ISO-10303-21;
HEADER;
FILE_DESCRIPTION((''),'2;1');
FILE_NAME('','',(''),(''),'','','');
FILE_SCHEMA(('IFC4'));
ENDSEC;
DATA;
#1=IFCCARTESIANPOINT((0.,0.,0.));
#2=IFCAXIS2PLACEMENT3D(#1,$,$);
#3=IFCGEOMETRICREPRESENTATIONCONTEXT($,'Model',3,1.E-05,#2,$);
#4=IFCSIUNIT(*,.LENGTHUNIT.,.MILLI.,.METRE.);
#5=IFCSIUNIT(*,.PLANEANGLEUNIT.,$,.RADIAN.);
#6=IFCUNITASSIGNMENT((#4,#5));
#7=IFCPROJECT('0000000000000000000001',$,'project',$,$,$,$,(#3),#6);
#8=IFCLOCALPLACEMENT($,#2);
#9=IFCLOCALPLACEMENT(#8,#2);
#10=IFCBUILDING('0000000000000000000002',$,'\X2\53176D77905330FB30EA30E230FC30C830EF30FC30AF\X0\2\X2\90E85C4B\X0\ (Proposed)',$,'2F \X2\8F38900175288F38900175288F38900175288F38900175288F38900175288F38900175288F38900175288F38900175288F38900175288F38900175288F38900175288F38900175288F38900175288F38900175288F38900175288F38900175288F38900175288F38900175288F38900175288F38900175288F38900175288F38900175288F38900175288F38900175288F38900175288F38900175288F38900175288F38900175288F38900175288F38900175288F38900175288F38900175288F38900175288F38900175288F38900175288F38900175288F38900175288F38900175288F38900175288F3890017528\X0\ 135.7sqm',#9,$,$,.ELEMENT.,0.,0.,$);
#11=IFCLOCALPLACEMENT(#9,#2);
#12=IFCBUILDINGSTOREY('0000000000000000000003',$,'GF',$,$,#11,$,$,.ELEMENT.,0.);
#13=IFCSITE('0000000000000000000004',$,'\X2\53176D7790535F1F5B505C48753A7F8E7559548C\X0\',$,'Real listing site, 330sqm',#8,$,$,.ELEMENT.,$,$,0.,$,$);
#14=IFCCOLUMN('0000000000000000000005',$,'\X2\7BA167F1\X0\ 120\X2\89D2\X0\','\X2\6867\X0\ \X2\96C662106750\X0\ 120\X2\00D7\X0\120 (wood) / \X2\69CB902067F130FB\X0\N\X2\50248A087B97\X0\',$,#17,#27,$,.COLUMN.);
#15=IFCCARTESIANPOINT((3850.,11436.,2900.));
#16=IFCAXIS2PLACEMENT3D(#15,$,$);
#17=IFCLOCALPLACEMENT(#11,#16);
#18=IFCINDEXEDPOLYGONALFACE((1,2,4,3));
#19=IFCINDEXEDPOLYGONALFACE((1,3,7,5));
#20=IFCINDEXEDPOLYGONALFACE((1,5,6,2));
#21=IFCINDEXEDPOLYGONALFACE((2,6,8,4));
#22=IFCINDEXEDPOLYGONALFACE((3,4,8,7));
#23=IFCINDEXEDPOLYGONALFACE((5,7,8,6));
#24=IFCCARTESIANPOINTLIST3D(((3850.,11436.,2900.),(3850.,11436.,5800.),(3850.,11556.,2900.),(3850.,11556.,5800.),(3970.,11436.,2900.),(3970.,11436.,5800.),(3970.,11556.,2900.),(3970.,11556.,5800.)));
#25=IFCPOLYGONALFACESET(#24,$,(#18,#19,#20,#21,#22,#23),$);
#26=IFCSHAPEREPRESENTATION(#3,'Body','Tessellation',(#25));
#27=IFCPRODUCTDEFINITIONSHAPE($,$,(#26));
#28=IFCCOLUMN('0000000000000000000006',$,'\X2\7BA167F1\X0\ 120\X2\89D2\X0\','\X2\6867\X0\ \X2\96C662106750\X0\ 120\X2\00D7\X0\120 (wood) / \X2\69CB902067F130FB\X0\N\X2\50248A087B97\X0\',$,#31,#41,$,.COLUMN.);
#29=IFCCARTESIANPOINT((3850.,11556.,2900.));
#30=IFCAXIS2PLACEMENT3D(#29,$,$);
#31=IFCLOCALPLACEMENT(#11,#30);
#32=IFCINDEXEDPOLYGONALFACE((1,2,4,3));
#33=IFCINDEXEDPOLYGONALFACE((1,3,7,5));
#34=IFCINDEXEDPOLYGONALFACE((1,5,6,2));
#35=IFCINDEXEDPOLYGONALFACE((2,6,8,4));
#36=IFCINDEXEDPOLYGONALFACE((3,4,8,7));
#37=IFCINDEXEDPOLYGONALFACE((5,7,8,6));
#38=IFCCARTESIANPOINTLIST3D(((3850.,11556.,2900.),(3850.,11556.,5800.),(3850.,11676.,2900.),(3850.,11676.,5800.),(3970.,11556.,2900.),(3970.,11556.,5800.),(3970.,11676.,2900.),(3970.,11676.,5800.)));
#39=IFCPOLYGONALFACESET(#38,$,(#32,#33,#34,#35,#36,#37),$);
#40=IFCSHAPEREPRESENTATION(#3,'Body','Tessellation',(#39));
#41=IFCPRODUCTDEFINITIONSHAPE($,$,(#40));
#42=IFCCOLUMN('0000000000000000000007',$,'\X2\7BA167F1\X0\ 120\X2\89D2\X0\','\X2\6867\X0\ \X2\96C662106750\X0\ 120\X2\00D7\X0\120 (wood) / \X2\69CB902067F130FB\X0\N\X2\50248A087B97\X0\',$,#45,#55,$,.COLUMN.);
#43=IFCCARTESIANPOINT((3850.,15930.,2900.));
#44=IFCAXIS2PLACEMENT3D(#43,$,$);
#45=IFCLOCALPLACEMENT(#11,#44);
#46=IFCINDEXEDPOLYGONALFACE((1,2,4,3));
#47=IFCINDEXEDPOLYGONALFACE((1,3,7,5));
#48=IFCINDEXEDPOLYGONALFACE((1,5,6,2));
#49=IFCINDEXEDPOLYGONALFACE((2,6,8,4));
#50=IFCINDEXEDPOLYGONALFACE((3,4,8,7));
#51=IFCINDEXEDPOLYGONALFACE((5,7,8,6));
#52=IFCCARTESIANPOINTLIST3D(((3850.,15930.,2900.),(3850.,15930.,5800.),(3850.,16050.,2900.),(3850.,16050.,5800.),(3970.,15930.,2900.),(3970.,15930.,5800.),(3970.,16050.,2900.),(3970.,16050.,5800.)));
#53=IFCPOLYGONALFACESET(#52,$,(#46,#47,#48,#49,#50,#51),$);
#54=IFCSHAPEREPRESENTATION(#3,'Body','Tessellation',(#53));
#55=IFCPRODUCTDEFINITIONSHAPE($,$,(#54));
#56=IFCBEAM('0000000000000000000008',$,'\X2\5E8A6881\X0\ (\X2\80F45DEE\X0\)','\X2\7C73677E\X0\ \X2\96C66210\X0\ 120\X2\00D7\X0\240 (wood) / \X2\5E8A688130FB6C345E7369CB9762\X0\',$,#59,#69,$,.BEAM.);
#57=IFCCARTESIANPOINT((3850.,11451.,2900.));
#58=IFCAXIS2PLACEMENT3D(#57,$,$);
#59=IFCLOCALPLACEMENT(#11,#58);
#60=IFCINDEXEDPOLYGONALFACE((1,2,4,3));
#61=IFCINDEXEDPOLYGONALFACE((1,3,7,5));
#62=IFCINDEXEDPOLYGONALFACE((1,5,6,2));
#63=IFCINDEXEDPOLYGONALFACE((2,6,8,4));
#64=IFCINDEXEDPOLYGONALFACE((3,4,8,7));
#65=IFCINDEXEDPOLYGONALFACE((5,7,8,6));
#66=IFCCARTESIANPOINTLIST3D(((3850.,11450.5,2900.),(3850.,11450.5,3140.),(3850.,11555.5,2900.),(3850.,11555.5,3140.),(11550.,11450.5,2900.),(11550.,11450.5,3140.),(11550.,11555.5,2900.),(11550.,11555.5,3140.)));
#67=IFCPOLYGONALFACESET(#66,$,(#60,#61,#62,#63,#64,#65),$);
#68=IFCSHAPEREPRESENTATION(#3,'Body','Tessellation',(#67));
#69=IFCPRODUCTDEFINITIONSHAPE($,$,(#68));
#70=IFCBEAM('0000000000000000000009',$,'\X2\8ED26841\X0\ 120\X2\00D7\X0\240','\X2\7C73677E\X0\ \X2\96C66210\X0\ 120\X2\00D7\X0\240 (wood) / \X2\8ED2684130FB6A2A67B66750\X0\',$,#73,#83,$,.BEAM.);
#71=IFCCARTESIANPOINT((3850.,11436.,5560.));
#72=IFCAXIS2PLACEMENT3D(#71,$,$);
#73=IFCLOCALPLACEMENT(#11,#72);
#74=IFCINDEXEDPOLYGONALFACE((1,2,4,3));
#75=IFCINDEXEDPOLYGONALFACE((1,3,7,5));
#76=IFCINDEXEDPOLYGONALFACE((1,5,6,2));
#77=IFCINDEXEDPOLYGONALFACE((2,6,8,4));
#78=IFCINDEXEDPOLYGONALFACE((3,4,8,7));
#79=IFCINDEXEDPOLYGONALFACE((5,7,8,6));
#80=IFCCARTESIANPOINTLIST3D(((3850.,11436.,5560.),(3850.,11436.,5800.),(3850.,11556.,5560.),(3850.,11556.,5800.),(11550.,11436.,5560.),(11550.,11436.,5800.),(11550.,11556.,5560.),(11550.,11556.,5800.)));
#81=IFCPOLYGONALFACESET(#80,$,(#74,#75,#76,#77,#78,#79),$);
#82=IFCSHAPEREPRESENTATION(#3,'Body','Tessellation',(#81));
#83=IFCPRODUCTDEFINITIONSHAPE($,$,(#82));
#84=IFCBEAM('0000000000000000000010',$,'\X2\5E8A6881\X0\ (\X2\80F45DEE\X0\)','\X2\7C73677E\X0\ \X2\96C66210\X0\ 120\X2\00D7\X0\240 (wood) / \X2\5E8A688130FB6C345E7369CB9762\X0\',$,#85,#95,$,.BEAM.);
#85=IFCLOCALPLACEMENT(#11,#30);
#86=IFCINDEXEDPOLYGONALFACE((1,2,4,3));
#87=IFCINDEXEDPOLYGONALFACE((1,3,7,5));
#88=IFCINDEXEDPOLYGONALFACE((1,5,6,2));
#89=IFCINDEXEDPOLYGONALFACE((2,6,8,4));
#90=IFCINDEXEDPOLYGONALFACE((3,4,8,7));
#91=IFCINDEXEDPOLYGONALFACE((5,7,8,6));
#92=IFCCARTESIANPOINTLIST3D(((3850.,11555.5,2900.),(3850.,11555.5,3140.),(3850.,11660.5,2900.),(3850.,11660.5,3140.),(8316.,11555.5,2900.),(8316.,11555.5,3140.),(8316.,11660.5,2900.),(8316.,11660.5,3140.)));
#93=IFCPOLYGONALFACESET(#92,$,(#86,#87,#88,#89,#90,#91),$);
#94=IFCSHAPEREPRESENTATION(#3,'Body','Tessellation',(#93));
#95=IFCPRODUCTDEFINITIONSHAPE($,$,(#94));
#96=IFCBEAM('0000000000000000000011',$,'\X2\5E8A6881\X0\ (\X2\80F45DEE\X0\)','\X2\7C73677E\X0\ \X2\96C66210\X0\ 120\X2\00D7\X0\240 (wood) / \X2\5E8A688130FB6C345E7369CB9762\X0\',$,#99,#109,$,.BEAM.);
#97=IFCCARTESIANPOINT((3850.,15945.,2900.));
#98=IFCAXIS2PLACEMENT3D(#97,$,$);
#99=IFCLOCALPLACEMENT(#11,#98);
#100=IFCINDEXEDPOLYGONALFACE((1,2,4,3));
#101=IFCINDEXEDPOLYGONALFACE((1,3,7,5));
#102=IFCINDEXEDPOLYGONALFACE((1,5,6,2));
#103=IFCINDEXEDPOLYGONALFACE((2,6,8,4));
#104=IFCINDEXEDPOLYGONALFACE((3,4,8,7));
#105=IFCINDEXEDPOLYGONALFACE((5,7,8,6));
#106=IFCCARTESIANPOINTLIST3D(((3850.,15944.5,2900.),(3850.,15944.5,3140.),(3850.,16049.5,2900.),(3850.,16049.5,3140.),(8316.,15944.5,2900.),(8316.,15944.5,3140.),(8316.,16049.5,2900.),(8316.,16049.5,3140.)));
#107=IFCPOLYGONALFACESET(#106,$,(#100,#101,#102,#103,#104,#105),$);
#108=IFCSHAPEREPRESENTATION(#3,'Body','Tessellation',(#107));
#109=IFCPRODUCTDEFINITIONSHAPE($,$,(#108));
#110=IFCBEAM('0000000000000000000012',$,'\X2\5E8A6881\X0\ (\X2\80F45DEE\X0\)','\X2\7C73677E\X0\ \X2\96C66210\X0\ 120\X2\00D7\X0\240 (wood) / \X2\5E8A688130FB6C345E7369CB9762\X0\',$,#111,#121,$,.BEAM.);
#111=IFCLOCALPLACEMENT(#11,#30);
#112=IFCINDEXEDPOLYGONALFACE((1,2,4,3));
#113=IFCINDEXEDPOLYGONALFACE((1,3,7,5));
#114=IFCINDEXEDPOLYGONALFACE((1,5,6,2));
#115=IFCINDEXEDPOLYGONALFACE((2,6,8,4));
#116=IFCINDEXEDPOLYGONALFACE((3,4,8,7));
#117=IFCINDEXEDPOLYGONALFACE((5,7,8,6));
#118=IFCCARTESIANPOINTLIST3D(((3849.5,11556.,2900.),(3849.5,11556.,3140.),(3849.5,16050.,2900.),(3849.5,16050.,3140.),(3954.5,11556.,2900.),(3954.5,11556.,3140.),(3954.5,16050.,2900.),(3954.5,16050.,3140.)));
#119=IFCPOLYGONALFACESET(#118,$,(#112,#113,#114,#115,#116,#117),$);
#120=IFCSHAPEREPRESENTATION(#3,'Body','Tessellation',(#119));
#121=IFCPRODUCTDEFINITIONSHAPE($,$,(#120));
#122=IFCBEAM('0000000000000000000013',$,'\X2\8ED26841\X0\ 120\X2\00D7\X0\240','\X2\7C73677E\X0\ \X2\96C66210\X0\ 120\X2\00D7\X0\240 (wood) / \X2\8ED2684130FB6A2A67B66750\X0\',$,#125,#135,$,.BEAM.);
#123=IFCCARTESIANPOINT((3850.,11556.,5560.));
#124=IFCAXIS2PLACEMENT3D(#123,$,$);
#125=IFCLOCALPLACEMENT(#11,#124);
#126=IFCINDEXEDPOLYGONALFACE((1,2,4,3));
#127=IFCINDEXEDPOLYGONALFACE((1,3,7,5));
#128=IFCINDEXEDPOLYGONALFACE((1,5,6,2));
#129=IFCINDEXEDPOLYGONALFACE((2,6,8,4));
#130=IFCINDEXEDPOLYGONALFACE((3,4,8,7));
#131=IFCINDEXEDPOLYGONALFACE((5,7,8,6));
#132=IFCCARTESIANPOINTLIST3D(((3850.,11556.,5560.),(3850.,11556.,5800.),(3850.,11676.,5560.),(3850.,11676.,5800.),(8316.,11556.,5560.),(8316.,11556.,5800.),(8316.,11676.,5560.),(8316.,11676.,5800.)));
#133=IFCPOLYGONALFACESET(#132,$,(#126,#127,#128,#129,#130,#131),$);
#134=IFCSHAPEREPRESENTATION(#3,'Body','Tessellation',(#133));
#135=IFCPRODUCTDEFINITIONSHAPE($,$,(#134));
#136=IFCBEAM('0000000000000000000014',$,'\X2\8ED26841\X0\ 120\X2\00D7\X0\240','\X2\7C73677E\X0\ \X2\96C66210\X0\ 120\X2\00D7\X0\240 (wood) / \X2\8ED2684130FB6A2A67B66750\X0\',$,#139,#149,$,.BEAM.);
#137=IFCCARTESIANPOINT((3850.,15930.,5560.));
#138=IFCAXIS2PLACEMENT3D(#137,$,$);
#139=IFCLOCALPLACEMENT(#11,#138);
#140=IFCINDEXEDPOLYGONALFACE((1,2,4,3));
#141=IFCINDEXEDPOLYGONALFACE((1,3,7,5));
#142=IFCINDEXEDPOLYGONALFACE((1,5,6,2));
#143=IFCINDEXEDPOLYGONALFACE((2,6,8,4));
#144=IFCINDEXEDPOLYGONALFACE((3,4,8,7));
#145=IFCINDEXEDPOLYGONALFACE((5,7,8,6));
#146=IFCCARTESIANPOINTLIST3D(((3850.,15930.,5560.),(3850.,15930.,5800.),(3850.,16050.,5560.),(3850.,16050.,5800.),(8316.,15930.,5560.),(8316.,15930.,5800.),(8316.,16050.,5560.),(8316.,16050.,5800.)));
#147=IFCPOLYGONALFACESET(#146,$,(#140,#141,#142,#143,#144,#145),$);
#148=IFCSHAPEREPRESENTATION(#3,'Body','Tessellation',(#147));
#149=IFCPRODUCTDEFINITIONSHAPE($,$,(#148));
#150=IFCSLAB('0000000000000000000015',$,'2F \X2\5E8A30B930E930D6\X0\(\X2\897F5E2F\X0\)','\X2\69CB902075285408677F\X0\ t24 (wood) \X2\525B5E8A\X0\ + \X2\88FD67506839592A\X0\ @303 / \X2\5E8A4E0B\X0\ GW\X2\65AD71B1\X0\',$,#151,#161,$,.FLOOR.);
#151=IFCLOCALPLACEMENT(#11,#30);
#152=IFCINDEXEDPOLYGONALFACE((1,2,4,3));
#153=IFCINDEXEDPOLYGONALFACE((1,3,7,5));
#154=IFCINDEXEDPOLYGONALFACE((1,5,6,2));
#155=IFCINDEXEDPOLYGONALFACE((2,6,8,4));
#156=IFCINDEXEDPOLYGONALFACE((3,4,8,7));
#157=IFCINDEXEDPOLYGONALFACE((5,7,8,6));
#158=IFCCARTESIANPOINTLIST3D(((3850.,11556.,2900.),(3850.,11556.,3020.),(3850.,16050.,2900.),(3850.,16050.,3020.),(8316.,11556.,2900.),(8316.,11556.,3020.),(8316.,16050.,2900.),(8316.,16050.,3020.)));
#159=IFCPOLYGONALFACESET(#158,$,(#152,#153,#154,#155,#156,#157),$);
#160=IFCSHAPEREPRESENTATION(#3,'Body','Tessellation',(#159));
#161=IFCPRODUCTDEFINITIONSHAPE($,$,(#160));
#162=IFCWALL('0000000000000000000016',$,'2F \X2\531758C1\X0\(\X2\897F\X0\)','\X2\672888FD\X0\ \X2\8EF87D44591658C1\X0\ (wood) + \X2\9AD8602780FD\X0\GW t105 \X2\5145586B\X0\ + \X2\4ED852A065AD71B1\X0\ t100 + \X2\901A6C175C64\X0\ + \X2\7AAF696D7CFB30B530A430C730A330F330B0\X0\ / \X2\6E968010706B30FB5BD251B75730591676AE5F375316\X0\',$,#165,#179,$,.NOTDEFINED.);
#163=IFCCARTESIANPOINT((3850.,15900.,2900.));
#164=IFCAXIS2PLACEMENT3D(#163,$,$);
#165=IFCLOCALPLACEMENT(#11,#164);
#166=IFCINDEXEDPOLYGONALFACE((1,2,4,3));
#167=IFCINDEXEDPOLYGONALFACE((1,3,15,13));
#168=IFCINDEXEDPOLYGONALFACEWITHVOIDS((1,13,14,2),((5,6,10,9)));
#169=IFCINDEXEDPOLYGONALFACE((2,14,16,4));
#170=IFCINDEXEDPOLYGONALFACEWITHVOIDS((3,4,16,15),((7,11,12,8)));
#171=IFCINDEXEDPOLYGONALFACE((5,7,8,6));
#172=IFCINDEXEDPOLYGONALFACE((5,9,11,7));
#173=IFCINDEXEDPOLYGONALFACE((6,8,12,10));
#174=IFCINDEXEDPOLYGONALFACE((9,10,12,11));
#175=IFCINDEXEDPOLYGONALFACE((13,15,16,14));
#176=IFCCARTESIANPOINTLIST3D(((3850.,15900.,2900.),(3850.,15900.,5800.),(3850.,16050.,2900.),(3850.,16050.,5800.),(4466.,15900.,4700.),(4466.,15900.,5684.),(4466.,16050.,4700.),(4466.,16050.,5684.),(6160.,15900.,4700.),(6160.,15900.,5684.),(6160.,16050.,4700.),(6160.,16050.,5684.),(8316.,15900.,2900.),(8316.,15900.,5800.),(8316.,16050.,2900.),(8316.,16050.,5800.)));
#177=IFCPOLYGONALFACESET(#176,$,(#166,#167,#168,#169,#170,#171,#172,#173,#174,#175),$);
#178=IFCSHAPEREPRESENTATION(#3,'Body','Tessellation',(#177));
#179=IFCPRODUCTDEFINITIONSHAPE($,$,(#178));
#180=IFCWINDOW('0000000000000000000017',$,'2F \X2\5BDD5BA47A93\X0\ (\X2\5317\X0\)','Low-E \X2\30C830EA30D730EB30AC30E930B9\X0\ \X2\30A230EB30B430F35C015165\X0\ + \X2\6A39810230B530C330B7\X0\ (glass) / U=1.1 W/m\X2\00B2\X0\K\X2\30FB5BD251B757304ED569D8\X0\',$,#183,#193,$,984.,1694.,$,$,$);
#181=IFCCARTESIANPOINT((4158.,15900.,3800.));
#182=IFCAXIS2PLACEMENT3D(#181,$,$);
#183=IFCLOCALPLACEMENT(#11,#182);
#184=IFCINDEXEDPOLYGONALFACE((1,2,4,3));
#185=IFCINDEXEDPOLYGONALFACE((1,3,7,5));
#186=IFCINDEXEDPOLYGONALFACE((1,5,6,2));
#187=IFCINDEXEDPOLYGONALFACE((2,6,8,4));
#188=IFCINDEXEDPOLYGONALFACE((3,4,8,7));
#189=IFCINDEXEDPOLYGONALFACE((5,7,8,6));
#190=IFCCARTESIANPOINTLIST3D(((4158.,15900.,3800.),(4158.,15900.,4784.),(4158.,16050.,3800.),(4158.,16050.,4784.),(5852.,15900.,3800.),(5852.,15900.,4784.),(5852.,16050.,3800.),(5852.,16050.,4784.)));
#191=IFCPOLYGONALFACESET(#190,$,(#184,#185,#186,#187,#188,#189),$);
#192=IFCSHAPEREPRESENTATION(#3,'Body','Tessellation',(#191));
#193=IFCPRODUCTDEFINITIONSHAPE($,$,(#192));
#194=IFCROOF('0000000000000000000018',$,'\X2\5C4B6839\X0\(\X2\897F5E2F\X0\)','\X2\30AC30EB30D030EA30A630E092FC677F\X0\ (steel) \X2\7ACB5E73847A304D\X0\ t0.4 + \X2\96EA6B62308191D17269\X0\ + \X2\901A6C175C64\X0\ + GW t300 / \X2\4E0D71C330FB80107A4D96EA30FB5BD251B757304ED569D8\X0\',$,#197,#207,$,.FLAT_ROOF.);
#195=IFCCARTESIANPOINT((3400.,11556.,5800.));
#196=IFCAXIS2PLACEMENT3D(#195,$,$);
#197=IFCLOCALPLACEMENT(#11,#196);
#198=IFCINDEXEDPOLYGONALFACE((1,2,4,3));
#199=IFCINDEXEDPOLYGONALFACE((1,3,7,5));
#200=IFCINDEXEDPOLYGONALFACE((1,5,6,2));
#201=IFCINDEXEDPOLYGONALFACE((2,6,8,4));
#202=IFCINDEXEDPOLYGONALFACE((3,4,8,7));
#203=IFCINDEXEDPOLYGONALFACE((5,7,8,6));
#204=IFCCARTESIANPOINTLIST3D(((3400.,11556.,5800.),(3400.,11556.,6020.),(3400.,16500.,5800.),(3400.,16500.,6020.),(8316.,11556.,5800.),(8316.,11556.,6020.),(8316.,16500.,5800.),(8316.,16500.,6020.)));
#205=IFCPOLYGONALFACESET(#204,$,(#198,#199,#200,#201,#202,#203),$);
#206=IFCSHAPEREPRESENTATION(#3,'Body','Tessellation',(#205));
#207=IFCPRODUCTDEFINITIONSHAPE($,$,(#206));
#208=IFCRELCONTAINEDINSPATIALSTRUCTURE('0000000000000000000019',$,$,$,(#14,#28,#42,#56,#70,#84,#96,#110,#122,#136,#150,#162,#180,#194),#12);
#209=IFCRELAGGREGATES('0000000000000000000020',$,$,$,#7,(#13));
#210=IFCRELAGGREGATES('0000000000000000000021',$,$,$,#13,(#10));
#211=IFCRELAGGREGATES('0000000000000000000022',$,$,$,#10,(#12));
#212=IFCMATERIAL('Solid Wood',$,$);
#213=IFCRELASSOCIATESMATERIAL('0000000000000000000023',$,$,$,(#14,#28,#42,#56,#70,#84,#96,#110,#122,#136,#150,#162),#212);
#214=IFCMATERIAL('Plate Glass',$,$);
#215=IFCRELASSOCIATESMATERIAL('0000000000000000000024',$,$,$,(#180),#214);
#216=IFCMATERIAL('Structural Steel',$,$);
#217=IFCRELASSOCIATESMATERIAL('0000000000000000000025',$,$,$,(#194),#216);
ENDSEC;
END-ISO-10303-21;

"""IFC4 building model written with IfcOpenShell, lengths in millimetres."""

from ifc_helpers import new_model, si_unit, frame, frame_2d, origin, place, context, project, spatial, rectangle, extrude, material, element, fill, save


model = new_model("IFC4")

# Units and contexts
model_context = context("Model", 3, precision=1e-05, world=origin())
ifc_project = project(units=[si_unit("LENGTHUNIT", "METRE", prefix="MILLI"), si_unit("PLANEANGLEUNIT", "RADIAN")], contexts=[model_context])

# Site, building, storey
site_placement = place(None, origin())
site = spatial("IfcSite", under=ifc_project, at=site_placement, Name="北海道弟子屈町美留和", ObjectType="Real listing site, 330sqm", CompositionType="ELEMENT", RefElevation=0.0)
building_placement = place(site_placement, origin())
building = spatial("IfcBuilding", under=site, at=building_placement, Name="北海道・リモートワーク2部屋 (Proposed)", ObjectType="2F 輸送用輸送用輸送用輸送用輸送用輸送用輸送用輸送用輸送用輸送用輸送用輸送用輸送用輸送用輸送用輸送用輸送用輸送用輸送用輸送用輸送用輸送用輸送用輸送用輸送用輸送用輸送用輸送用輸送用輸送用輸送用輸送用輸送用輸送用輸送用輸送用輸送用輸送用輸送用輸送用 135.7sqm", CompositionType="ELEMENT", ElevationOfRefHeight=0.0, ElevationOfTerrain=0.0)
storey_placement = place(building_placement, origin())
storey = spatial("IfcBuildingStorey", under=building, at=storey_placement, Name="GF", CompositionType="ELEMENT", Elevation=0.0)

# Columns
ifc_material_1 = material(Name="Solid Wood")
column_1_placement = place(storey_placement, frame((3850.0, 11436.0, 2900.0)))
element("IfcColumn", 1, at=column_1_placement, inside=storey, material=ifc_material_1, Name="管柱 120角", Description="桧 集成材 120×120 (wood) / 構造柱・N値計算", PredefinedType="COLUMN", context=model_context, shape_type="SweptSolid", body=[
    extrude(rectangle(XDim=120.0, YDim=120.0, at=frame_2d((60.0, 60.0))), frame((3850.0, 11436.0, 2900.0)), (0.0, 0.0, 1.0), 2900.0),
])
column_2_placement = place(storey_placement, frame((3850.0, 11556.0, 2900.0)))
element("IfcColumn", 2, at=column_2_placement, inside=storey, material=ifc_material_1, Name="管柱 120角", Description="桧 集成材 120×120 (wood) / 構造柱・N値計算", PredefinedType="COLUMN", context=model_context, shape_type="SweptSolid", body=[
    extrude(rectangle(XDim=120.0, YDim=120.0, at=frame_2d((60.0, 60.0))), frame((3850.0, 11556.0, 2900.0)), (0.0, 0.0, 1.0), 2900.0),
])
column_3_placement = place(storey_placement, frame((3850.0, 15930.0, 2900.0)))
element("IfcColumn", 3, at=column_3_placement, inside=storey, material=ifc_material_1, Name="管柱 120角", Description="桧 集成材 120×120 (wood) / 構造柱・N値計算", PredefinedType="COLUMN", context=model_context, shape_type="SweptSolid", body=[
    extrude(rectangle(XDim=120.0, YDim=120.0, at=frame_2d((60.0, 60.0))), frame((3850.0, 15930.0, 2900.0)), (0.0, 0.0, 1.0), 2900.0),
])

# Beams
beam_1_placement = place(storey_placement, frame((3850.0, 11451.0, 2900.0)))
element("IfcBeam", 4, at=beam_1_placement, inside=storey, material=ifc_material_1, Name="床梁 (胴差)", Description="米松 集成 120×240 (wood) / 床梁・水平構面", PredefinedType="BEAM", context=model_context, shape_type="SweptSolid", body=[
    extrude(rectangle(XDim=7700.0, YDim=105.0, at=frame_2d((3850.0, 52.0))), frame((3850.0, 11451.0, 2900.0)), (0.0, 0.0, 1.0), 240.0),
])
beam_2_placement = place(storey_placement, frame((3850.0, 11436.0, 5560.0)))
element("IfcBeam", 5, at=beam_2_placement, inside=storey, material=ifc_material_1, Name="軒桁 120×240", Description="米松 集成 120×240 (wood) / 軒桁・横架材", PredefinedType="BEAM", context=model_context, shape_type="SweptSolid", body=[
    extrude(rectangle(XDim=7700.0, YDim=120.0, at=frame_2d((3850.0, 60.0))), frame((3850.0, 11436.0, 5560.0)), (0.0, 0.0, 1.0), 240.0),
])
beam_3_placement = place(storey_placement, frame((3850.0, 11556.0, 2900.0)))
element("IfcBeam", 6, at=beam_3_placement, inside=storey, material=ifc_material_1, Name="床梁 (胴差)", Description="米松 集成 120×240 (wood) / 床梁・水平構面", PredefinedType="BEAM", context=model_context, shape_type="SweptSolid", body=[
    extrude(rectangle(XDim=4466.0, YDim=105.0, at=frame_2d((2233.0, 52.0))), frame((3850.0, 11556.0, 2900.0)), (0.0, 0.0, 1.0), 240.0),
])
beam_4_placement = place(storey_placement, frame((3850.0, 15945.0, 2900.0)))
element("IfcBeam", 7, at=beam_4_placement, inside=storey, material=ifc_material_1, Name="床梁 (胴差)", Description="米松 集成 120×240 (wood) / 床梁・水平構面", PredefinedType="BEAM", context=model_context, shape_type="SweptSolid", body=[
    extrude(rectangle(XDim=4466.0, YDim=105.0, at=frame_2d((2233.0, 52.0))), frame((3850.0, 15945.0, 2900.0)), (0.0, 0.0, 1.0), 240.0),
])
beam_5_placement = place(storey_placement, frame((3850.0, 11556.0, 2900.0)))
element("IfcBeam", 8, at=beam_5_placement, inside=storey, material=ifc_material_1, Name="床梁 (胴差)", Description="米松 集成 120×240 (wood) / 床梁・水平構面", PredefinedType="BEAM", context=model_context, shape_type="SweptSolid", body=[
    extrude(rectangle(XDim=105.0, YDim=4494.0, at=frame_2d((52.0, 2247.0))), frame((3850.0, 11556.0, 2900.0)), (0.0, 0.0, 1.0), 240.0),
])
beam_6_placement = place(storey_placement, frame((3850.0, 11556.0, 5560.0)))
element("IfcBeam", 9, at=beam_6_placement, inside=storey, material=ifc_material_1, Name="軒桁 120×240", Description="米松 集成 120×240 (wood) / 軒桁・横架材", PredefinedType="BEAM", context=model_context, shape_type="SweptSolid", body=[
    extrude(rectangle(XDim=4466.0, YDim=120.0, at=frame_2d((2233.0, 60.0))), frame((3850.0, 11556.0, 5560.0)), (0.0, 0.0, 1.0), 240.0),
])
beam_7_placement = place(storey_placement, frame((3850.0, 15930.0, 5560.0)))
element("IfcBeam", 10, at=beam_7_placement, inside=storey, material=ifc_material_1, Name="軒桁 120×240", Description="米松 集成 120×240 (wood) / 軒桁・横架材", PredefinedType="BEAM", context=model_context, shape_type="SweptSolid", body=[
    extrude(rectangle(XDim=4466.0, YDim=120.0, at=frame_2d((2233.0, 60.0))), frame((3850.0, 15930.0, 5560.0)), (0.0, 0.0, 1.0), 240.0),
])

# Slab
slab_placement = place(storey_placement, frame((3850.0, 11556.0, 2900.0)))
element("IfcSlab", 11, at=slab_placement, inside=storey, material=ifc_material_1, Name="2F 床スラブ(西帯)", Description="構造用合板 t24 (wood) 剛床 + 製材根太 @303 / 床下 GW断熱", PredefinedType="FLOOR", context=model_context, shape_type="SweptSolid", body=[
    extrude(rectangle(XDim=4466.0, YDim=4494.0, at=frame_2d((2233.0, 2247.0))), frame((3850.0, 11556.0, 2900.0)), (0.0, 0.0, 1.0), 120.0),
])

# Wall, opening, window
wall_1_placement = place(storey_placement, frame((3850.0, 15900.0, 2900.0)))
wall_1 = element("IfcWall", 12, at=wall_1_placement, inside=storey, material=ifc_material_1, Name="2F 北壁(西)", Description="木製 軸組外壁 (wood) + 高性能GW t105 充填 + 付加断熱 t100 + 通気層 + 窯業系サイディング / 準耐火・寒冷地外皮強化", PredefinedType="NOTDEFINED", context=model_context, shape_type="SweptSolid", body=[
    extrude(rectangle(XDim=4466.0, YDim=150.0, at=frame_2d((2233.0, 75.0))), frame((3850.0, 15900.0, 2900.0)), (0.0, 0.0, 1.0), 2900.0),
])
opening_placement = place(storey_placement, frame((4158.0, 15900.0, 3800.0)))
opening = element("IfcOpeningElement", 13, at=opening_placement, cuts=wall_1, PredefinedType="NOTDEFINED", context=model_context, shape_type="SweptSolid", body=[
    extrude(rectangle(XDim=1694.0, YDim=150.0, at=frame_2d((847.0, 75.0))), frame((4158.0, 15900.0, 3800.0)), (0.0, 0.0, 1.0), 984.0),
])
ifc_material_2 = material(Name="Plate Glass")
window_placement = place(storey_placement, frame((4158.0, 15900.0, 3800.0)))
window = element("IfcWindow", 14, at=window_placement, inside=storey, material=ifc_material_2, Name="2F 寝室窓 (北)", Description="Low-E トリプルガラス アルゴン封入 + 樹脂サッシ (glass) / U=1.1 W/m²K・寒冷地仕様", OverallHeight=984.0, OverallWidth=1694.0, context=model_context, shape_type="SweptSolid", body=[
    extrude(rectangle(XDim=1694.0, YDim=150.0, at=frame_2d((847.0, 75.0))), frame((4158.0, 15900.0, 3800.0)), (0.0, 0.0, 1.0), 984.0),
])
fill(opening, window)

# Roof
ifc_material_3 = material(Name="Structural Steel")
for number, where, name in (
    (15, (3400.0, 11556.0, 5800.0), "屋根(西帯)"),
):
    element("IfcRoof", number, at=place(storey_placement, frame(where)), inside=storey, material=ifc_material_3, Name=name, Description="ガルバリウム鋼板 (steel) 立平葺き t0.4 + 雪止め金物 + 通気層 + GW t300 / 不燃・耐積雪・寒冷地仕様", PredefinedType="FLAT_ROOF", context=model_context, shape_type="SweptSolid", body=[
        extrude(rectangle(XDim=4916.0, YDim=4944.0, at=frame_2d((2458.0, 2472.0))), frame((3400.0, 11556.0, 5800.0)), (0.0, 0.0, 1.0), 220.0),
    ])

save(model, "model.ifc")
